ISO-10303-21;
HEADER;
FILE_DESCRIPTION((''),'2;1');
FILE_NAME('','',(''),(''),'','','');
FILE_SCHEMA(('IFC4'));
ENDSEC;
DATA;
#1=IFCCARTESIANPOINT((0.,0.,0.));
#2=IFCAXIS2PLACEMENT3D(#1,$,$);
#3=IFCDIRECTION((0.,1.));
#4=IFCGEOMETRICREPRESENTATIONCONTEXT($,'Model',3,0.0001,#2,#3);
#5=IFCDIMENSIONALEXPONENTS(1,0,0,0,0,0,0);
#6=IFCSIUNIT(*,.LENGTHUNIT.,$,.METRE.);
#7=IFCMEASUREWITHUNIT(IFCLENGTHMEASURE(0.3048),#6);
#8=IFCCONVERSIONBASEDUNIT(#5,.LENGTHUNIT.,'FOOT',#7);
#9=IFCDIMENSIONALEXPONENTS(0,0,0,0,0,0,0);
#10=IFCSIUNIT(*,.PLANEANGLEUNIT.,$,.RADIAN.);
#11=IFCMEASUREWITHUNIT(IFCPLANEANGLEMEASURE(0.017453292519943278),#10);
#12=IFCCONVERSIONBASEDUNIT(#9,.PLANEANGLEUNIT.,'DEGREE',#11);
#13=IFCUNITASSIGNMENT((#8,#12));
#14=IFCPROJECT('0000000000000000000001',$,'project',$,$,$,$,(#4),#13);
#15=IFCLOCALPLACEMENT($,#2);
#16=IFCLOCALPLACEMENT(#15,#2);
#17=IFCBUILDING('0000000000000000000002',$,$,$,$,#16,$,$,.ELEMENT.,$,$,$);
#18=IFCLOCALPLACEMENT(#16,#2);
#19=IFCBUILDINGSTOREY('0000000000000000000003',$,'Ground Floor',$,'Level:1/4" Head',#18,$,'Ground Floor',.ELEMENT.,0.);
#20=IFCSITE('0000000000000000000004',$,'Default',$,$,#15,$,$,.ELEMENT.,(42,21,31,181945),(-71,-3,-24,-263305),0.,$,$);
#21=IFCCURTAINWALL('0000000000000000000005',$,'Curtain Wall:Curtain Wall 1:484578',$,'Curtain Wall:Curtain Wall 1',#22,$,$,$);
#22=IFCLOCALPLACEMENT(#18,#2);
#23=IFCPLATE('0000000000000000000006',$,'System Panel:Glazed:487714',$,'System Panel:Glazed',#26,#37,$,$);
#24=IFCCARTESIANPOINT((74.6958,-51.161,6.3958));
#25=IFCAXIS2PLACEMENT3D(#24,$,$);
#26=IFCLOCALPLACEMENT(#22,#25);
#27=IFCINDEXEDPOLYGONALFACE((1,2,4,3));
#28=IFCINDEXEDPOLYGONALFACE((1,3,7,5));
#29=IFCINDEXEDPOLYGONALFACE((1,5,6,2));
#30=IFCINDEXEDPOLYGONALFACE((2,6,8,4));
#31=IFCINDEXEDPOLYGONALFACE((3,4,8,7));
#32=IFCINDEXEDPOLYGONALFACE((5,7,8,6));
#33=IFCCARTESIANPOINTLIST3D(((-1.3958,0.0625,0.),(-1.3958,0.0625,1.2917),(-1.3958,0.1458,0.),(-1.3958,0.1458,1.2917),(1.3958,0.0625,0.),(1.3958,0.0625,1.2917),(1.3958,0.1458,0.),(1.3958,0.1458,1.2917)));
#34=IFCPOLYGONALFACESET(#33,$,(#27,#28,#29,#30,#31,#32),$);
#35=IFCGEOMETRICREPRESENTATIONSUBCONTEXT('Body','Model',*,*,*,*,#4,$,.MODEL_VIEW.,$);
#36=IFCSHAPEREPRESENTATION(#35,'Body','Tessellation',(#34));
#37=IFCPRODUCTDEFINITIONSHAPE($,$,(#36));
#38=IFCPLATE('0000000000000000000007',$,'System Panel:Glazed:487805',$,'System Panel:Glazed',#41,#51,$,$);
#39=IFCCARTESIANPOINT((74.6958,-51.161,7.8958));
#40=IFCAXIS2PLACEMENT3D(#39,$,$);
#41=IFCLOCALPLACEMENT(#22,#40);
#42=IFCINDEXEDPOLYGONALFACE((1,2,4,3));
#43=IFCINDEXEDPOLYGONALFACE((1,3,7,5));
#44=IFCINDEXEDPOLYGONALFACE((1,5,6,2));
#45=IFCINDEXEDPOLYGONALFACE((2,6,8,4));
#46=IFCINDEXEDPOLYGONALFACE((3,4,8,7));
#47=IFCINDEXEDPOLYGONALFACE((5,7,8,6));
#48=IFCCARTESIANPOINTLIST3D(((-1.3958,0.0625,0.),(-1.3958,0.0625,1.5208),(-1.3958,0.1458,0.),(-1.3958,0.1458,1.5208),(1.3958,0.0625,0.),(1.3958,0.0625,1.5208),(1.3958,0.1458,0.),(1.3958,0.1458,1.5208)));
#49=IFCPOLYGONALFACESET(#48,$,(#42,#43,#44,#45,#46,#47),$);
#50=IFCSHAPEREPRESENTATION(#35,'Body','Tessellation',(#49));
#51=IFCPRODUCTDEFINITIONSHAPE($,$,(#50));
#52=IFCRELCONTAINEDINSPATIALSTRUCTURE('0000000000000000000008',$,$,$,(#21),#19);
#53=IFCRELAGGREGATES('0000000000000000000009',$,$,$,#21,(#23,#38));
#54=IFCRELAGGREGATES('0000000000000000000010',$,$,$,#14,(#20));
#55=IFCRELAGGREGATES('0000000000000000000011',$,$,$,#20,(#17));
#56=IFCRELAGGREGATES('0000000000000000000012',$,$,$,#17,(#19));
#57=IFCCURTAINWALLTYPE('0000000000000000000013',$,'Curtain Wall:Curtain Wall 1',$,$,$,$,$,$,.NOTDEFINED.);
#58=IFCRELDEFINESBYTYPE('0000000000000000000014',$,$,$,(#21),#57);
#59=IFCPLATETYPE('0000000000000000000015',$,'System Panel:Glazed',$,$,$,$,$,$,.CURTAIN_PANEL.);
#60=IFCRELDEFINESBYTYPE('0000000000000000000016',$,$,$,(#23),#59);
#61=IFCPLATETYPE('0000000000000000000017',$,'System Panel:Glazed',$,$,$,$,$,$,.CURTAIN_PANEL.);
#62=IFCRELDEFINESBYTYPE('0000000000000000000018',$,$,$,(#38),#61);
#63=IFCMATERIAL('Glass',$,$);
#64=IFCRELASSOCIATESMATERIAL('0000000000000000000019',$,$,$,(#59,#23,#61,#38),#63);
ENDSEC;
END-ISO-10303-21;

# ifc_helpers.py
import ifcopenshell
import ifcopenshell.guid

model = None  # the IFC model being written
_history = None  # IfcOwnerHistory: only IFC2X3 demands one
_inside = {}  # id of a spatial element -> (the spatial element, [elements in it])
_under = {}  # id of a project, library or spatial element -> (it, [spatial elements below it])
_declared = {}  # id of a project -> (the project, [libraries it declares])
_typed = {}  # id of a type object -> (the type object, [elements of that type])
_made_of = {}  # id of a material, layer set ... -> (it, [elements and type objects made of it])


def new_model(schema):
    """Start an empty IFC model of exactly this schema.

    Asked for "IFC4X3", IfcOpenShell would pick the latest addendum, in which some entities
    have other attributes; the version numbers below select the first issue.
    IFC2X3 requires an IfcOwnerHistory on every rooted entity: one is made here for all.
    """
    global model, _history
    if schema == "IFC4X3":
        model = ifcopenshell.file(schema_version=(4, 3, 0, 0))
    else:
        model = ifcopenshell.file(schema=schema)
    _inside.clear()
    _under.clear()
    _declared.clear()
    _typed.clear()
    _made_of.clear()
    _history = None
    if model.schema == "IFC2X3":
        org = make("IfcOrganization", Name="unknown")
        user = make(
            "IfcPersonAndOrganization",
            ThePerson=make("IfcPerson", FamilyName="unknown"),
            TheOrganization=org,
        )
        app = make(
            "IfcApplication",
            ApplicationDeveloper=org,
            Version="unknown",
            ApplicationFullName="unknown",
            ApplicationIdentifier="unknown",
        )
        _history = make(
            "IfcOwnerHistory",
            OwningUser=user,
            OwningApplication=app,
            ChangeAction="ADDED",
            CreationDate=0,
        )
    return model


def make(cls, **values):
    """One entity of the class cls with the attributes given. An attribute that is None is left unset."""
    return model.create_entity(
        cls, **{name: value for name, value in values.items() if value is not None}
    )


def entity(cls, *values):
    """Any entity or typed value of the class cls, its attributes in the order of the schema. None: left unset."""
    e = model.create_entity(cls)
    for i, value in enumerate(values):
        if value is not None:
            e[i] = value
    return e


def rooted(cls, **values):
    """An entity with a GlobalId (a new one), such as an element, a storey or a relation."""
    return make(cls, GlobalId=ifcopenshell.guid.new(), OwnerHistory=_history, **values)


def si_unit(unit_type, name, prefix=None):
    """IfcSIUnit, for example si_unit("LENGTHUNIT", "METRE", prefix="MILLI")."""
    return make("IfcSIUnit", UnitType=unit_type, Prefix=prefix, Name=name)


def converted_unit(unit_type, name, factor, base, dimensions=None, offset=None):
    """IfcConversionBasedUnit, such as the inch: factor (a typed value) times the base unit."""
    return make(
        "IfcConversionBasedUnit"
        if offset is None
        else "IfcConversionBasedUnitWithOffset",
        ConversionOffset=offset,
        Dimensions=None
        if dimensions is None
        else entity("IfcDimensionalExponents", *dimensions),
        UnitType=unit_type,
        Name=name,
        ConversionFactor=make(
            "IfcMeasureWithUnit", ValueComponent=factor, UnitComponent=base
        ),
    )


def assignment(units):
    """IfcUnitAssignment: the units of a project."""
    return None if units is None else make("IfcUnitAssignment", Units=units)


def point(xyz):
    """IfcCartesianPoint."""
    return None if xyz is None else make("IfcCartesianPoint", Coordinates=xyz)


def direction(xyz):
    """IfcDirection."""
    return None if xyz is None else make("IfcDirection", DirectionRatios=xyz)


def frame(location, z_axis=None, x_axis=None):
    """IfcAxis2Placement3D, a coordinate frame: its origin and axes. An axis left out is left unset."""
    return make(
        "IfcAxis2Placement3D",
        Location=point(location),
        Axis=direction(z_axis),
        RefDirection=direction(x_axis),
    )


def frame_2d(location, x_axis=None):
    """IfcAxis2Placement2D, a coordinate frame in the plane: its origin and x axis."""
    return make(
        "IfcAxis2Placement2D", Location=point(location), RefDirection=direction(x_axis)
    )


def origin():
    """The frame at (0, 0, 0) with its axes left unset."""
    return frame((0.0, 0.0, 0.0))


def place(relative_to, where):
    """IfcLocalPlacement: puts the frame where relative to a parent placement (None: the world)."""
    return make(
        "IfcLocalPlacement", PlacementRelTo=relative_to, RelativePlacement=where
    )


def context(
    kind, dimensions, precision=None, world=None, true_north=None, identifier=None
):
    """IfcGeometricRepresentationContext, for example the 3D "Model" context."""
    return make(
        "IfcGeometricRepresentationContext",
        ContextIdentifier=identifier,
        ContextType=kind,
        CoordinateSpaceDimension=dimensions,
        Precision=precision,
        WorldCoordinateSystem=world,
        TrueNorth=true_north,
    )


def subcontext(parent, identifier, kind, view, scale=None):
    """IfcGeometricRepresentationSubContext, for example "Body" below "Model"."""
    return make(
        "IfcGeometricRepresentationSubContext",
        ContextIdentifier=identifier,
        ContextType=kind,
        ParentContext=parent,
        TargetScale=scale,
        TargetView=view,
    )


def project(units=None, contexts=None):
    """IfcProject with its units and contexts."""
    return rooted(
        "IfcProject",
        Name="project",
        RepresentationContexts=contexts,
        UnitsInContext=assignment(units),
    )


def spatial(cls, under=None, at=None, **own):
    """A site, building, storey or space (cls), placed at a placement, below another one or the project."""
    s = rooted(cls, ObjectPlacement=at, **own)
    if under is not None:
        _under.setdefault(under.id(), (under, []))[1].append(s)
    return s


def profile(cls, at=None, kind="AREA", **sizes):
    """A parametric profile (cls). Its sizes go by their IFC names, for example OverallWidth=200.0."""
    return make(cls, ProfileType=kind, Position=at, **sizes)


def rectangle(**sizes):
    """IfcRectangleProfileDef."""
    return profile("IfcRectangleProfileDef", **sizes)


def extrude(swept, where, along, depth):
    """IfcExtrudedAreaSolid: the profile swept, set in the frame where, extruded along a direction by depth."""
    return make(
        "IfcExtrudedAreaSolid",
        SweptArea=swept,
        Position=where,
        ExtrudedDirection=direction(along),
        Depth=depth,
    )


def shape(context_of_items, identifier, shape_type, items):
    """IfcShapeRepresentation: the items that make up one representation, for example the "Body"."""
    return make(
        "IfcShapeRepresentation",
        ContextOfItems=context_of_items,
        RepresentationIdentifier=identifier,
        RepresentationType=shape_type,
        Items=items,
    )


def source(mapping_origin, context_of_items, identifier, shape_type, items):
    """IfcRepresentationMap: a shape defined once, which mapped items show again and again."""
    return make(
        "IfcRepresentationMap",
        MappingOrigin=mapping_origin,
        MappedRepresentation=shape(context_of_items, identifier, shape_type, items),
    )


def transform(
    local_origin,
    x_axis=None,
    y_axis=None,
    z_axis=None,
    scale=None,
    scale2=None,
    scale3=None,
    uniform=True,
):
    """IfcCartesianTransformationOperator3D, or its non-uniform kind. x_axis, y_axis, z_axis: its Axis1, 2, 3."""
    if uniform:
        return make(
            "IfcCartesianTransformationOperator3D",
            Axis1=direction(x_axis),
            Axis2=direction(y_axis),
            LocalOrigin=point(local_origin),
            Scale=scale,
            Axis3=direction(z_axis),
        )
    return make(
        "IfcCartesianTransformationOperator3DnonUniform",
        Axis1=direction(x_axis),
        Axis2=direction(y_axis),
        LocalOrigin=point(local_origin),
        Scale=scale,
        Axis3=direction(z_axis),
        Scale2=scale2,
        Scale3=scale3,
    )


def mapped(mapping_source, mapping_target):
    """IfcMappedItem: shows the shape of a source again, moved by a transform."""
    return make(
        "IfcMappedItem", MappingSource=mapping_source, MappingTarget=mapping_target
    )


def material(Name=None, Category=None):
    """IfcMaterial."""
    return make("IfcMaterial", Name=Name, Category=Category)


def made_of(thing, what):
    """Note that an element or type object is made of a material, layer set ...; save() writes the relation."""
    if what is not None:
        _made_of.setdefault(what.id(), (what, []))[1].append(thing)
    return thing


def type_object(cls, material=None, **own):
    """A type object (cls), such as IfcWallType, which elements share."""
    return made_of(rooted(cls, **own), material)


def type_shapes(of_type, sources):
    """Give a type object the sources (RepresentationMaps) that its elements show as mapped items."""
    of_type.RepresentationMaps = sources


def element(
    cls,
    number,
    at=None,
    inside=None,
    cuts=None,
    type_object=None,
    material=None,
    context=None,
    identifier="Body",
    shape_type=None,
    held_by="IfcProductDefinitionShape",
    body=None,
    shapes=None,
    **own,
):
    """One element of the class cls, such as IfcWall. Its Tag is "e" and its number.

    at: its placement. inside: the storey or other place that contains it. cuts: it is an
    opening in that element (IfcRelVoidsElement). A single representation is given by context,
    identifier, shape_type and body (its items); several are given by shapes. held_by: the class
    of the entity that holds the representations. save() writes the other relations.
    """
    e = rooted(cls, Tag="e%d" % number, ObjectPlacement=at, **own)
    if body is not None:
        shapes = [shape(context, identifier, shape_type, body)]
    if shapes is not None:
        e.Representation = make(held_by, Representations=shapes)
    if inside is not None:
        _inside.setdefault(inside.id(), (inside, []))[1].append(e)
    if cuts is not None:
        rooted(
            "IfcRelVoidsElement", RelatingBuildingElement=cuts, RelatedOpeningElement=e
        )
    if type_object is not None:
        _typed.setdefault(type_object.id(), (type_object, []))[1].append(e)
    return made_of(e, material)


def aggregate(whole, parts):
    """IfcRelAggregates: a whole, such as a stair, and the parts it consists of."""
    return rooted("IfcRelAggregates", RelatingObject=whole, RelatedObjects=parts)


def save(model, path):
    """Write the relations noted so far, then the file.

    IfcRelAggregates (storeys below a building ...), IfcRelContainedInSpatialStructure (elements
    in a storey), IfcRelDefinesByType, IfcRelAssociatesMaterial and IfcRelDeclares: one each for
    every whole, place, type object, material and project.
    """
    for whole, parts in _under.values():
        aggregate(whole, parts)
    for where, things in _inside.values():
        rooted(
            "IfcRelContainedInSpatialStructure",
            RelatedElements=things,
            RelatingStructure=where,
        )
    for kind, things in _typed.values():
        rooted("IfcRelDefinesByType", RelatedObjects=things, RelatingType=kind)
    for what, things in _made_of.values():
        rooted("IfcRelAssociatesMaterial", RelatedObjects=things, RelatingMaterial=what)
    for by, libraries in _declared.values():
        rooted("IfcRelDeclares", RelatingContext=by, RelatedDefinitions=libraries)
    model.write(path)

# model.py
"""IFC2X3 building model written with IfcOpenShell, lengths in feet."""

from ifc_helpers import new_model, entity, si_unit, converted_unit, direction, frame, frame_2d, origin, place, context, subcontext, project, spatial, rectangle, extrude, source, transform, mapped, material, type_object, type_shapes, element, aggregate, save


model = new_model("IFC2X3")

# Units and contexts
model_context = context("Model", 3, precision=0.0001, world=origin(), true_north=direction((0.0, 1.0)))
body_context = subcontext(model_context, "Body", "Model", "MODEL_VIEW")
ifc_project = project(units=[converted_unit("LENGTHUNIT", "FOOT", entity("IfcLengthMeasure", 0.3048), si_unit("LENGTHUNIT", "METRE"), dimensions=[1, 0, 0, 0, 0, 0, 0]), converted_unit("PLANEANGLEUNIT", "DEGREE", entity("IfcPlaneAngleMeasure", 0.017453292519943278), si_unit("PLANEANGLEUNIT", "RADIAN"), dimensions=[0, 0, 0, 0, 0, 0, 0])], contexts=[model_context])

# Site, building, storey
site_placement = place(None, origin())
site = spatial("IfcSite", under=ifc_project, at=site_placement, Name="Default", CompositionType="ELEMENT", RefLatitude=(42, 21, 31, 181945), RefLongitude=(-71, -3, -24, -263305), RefElevation=0.0)
building_placement = place(site_placement, origin())
building = spatial("IfcBuilding", under=site, at=building_placement, CompositionType="ELEMENT")
storey_placement = place(building_placement, origin())
storey = spatial("IfcBuildingStorey", under=building, at=storey_placement, Name="Ground Floor", ObjectType="Level:1/4\" Head", LongName="Ground Floor", CompositionType="ELEMENT", Elevation=0.0)

# Curtain wall, plates
curtain_wall_type = type_object("IfcCurtainWallType", Name="Curtain Wall:Curtain Wall 1", PredefinedType="NOTDEFINED")
curtain_wall_placement = place(storey_placement, origin())
curtain_wall = element("IfcCurtainWall", 1, at=curtain_wall_placement, inside=storey, type_object=curtain_wall_type, Name="Curtain Wall:Curtain Wall 1:484578", ObjectType="Curtain Wall:Curtain Wall 1")
ifc_material_1 = material(Name="Glass")
plate_type_1 = type_object("IfcPlateType", Name="System Panel:Glazed", PredefinedType="CURTAIN_PANEL", material=ifc_material_1)
shared_shape_1 = source(origin(), body_context, "Body", "SweptSolid", [
    extrude(rectangle(XDim=0.0833, YDim=2.7917, at=frame_2d((0.0, 0.0), x_axis=(1.0, 0.0))), frame((0.0, 0.1042, 0.0), z_axis=(0.0, 0.0, 1.0), x_axis=(0.0, 1.0, 0.0)), (0.0, 0.0, 1.0), 1.2917),
])
type_shapes(plate_type_1, [shared_shape_1])
plate_1_placement = place(curtain_wall_placement, frame((74.6958, -51.161, 6.3958)))
plate_1 = element("IfcPlate", 2, at=plate_1_placement, type_object=plate_type_1, material=ifc_material_1, Name="System Panel:Glazed:487714", ObjectType="System Panel:Glazed", context=body_context, shape_type="MappedRepresentation", body=[
    mapped(shared_shape_1, transform((0.0, 0.0, 0.0), scale=1.0)),
])
plate_type_2 = type_object("IfcPlateType", Name="System Panel:Glazed", PredefinedType="CURTAIN_PANEL", material=ifc_material_1)
shared_shape_2 = source(origin(), body_context, "Body", "SweptSolid", [
    extrude(rectangle(XDim=0.0833, YDim=2.7917, at=frame_2d((0.0, 0.0), x_axis=(1.0, 0.0))), frame((0.0, 0.1042, 0.0), z_axis=(0.0, 0.0, 1.0), x_axis=(0.0, 1.0, 0.0)), (0.0, 0.0, 1.0), 1.5208),
])
type_shapes(plate_type_2, [shared_shape_2])
plate_2_placement = place(curtain_wall_placement, frame((74.6958, -51.161, 7.8958)))
plate_2 = element("IfcPlate", 3, at=plate_2_placement, type_object=plate_type_2, material=ifc_material_1, Name="System Panel:Glazed:487805", ObjectType="System Panel:Glazed", context=body_context, shape_type="MappedRepresentation", body=[
    mapped(shared_shape_2, transform((0.0, 0.0, 0.0), scale=1.0)),
])
aggregate(curtain_wall, [plate_1, plate_2])

save(model, "model.ifc")
